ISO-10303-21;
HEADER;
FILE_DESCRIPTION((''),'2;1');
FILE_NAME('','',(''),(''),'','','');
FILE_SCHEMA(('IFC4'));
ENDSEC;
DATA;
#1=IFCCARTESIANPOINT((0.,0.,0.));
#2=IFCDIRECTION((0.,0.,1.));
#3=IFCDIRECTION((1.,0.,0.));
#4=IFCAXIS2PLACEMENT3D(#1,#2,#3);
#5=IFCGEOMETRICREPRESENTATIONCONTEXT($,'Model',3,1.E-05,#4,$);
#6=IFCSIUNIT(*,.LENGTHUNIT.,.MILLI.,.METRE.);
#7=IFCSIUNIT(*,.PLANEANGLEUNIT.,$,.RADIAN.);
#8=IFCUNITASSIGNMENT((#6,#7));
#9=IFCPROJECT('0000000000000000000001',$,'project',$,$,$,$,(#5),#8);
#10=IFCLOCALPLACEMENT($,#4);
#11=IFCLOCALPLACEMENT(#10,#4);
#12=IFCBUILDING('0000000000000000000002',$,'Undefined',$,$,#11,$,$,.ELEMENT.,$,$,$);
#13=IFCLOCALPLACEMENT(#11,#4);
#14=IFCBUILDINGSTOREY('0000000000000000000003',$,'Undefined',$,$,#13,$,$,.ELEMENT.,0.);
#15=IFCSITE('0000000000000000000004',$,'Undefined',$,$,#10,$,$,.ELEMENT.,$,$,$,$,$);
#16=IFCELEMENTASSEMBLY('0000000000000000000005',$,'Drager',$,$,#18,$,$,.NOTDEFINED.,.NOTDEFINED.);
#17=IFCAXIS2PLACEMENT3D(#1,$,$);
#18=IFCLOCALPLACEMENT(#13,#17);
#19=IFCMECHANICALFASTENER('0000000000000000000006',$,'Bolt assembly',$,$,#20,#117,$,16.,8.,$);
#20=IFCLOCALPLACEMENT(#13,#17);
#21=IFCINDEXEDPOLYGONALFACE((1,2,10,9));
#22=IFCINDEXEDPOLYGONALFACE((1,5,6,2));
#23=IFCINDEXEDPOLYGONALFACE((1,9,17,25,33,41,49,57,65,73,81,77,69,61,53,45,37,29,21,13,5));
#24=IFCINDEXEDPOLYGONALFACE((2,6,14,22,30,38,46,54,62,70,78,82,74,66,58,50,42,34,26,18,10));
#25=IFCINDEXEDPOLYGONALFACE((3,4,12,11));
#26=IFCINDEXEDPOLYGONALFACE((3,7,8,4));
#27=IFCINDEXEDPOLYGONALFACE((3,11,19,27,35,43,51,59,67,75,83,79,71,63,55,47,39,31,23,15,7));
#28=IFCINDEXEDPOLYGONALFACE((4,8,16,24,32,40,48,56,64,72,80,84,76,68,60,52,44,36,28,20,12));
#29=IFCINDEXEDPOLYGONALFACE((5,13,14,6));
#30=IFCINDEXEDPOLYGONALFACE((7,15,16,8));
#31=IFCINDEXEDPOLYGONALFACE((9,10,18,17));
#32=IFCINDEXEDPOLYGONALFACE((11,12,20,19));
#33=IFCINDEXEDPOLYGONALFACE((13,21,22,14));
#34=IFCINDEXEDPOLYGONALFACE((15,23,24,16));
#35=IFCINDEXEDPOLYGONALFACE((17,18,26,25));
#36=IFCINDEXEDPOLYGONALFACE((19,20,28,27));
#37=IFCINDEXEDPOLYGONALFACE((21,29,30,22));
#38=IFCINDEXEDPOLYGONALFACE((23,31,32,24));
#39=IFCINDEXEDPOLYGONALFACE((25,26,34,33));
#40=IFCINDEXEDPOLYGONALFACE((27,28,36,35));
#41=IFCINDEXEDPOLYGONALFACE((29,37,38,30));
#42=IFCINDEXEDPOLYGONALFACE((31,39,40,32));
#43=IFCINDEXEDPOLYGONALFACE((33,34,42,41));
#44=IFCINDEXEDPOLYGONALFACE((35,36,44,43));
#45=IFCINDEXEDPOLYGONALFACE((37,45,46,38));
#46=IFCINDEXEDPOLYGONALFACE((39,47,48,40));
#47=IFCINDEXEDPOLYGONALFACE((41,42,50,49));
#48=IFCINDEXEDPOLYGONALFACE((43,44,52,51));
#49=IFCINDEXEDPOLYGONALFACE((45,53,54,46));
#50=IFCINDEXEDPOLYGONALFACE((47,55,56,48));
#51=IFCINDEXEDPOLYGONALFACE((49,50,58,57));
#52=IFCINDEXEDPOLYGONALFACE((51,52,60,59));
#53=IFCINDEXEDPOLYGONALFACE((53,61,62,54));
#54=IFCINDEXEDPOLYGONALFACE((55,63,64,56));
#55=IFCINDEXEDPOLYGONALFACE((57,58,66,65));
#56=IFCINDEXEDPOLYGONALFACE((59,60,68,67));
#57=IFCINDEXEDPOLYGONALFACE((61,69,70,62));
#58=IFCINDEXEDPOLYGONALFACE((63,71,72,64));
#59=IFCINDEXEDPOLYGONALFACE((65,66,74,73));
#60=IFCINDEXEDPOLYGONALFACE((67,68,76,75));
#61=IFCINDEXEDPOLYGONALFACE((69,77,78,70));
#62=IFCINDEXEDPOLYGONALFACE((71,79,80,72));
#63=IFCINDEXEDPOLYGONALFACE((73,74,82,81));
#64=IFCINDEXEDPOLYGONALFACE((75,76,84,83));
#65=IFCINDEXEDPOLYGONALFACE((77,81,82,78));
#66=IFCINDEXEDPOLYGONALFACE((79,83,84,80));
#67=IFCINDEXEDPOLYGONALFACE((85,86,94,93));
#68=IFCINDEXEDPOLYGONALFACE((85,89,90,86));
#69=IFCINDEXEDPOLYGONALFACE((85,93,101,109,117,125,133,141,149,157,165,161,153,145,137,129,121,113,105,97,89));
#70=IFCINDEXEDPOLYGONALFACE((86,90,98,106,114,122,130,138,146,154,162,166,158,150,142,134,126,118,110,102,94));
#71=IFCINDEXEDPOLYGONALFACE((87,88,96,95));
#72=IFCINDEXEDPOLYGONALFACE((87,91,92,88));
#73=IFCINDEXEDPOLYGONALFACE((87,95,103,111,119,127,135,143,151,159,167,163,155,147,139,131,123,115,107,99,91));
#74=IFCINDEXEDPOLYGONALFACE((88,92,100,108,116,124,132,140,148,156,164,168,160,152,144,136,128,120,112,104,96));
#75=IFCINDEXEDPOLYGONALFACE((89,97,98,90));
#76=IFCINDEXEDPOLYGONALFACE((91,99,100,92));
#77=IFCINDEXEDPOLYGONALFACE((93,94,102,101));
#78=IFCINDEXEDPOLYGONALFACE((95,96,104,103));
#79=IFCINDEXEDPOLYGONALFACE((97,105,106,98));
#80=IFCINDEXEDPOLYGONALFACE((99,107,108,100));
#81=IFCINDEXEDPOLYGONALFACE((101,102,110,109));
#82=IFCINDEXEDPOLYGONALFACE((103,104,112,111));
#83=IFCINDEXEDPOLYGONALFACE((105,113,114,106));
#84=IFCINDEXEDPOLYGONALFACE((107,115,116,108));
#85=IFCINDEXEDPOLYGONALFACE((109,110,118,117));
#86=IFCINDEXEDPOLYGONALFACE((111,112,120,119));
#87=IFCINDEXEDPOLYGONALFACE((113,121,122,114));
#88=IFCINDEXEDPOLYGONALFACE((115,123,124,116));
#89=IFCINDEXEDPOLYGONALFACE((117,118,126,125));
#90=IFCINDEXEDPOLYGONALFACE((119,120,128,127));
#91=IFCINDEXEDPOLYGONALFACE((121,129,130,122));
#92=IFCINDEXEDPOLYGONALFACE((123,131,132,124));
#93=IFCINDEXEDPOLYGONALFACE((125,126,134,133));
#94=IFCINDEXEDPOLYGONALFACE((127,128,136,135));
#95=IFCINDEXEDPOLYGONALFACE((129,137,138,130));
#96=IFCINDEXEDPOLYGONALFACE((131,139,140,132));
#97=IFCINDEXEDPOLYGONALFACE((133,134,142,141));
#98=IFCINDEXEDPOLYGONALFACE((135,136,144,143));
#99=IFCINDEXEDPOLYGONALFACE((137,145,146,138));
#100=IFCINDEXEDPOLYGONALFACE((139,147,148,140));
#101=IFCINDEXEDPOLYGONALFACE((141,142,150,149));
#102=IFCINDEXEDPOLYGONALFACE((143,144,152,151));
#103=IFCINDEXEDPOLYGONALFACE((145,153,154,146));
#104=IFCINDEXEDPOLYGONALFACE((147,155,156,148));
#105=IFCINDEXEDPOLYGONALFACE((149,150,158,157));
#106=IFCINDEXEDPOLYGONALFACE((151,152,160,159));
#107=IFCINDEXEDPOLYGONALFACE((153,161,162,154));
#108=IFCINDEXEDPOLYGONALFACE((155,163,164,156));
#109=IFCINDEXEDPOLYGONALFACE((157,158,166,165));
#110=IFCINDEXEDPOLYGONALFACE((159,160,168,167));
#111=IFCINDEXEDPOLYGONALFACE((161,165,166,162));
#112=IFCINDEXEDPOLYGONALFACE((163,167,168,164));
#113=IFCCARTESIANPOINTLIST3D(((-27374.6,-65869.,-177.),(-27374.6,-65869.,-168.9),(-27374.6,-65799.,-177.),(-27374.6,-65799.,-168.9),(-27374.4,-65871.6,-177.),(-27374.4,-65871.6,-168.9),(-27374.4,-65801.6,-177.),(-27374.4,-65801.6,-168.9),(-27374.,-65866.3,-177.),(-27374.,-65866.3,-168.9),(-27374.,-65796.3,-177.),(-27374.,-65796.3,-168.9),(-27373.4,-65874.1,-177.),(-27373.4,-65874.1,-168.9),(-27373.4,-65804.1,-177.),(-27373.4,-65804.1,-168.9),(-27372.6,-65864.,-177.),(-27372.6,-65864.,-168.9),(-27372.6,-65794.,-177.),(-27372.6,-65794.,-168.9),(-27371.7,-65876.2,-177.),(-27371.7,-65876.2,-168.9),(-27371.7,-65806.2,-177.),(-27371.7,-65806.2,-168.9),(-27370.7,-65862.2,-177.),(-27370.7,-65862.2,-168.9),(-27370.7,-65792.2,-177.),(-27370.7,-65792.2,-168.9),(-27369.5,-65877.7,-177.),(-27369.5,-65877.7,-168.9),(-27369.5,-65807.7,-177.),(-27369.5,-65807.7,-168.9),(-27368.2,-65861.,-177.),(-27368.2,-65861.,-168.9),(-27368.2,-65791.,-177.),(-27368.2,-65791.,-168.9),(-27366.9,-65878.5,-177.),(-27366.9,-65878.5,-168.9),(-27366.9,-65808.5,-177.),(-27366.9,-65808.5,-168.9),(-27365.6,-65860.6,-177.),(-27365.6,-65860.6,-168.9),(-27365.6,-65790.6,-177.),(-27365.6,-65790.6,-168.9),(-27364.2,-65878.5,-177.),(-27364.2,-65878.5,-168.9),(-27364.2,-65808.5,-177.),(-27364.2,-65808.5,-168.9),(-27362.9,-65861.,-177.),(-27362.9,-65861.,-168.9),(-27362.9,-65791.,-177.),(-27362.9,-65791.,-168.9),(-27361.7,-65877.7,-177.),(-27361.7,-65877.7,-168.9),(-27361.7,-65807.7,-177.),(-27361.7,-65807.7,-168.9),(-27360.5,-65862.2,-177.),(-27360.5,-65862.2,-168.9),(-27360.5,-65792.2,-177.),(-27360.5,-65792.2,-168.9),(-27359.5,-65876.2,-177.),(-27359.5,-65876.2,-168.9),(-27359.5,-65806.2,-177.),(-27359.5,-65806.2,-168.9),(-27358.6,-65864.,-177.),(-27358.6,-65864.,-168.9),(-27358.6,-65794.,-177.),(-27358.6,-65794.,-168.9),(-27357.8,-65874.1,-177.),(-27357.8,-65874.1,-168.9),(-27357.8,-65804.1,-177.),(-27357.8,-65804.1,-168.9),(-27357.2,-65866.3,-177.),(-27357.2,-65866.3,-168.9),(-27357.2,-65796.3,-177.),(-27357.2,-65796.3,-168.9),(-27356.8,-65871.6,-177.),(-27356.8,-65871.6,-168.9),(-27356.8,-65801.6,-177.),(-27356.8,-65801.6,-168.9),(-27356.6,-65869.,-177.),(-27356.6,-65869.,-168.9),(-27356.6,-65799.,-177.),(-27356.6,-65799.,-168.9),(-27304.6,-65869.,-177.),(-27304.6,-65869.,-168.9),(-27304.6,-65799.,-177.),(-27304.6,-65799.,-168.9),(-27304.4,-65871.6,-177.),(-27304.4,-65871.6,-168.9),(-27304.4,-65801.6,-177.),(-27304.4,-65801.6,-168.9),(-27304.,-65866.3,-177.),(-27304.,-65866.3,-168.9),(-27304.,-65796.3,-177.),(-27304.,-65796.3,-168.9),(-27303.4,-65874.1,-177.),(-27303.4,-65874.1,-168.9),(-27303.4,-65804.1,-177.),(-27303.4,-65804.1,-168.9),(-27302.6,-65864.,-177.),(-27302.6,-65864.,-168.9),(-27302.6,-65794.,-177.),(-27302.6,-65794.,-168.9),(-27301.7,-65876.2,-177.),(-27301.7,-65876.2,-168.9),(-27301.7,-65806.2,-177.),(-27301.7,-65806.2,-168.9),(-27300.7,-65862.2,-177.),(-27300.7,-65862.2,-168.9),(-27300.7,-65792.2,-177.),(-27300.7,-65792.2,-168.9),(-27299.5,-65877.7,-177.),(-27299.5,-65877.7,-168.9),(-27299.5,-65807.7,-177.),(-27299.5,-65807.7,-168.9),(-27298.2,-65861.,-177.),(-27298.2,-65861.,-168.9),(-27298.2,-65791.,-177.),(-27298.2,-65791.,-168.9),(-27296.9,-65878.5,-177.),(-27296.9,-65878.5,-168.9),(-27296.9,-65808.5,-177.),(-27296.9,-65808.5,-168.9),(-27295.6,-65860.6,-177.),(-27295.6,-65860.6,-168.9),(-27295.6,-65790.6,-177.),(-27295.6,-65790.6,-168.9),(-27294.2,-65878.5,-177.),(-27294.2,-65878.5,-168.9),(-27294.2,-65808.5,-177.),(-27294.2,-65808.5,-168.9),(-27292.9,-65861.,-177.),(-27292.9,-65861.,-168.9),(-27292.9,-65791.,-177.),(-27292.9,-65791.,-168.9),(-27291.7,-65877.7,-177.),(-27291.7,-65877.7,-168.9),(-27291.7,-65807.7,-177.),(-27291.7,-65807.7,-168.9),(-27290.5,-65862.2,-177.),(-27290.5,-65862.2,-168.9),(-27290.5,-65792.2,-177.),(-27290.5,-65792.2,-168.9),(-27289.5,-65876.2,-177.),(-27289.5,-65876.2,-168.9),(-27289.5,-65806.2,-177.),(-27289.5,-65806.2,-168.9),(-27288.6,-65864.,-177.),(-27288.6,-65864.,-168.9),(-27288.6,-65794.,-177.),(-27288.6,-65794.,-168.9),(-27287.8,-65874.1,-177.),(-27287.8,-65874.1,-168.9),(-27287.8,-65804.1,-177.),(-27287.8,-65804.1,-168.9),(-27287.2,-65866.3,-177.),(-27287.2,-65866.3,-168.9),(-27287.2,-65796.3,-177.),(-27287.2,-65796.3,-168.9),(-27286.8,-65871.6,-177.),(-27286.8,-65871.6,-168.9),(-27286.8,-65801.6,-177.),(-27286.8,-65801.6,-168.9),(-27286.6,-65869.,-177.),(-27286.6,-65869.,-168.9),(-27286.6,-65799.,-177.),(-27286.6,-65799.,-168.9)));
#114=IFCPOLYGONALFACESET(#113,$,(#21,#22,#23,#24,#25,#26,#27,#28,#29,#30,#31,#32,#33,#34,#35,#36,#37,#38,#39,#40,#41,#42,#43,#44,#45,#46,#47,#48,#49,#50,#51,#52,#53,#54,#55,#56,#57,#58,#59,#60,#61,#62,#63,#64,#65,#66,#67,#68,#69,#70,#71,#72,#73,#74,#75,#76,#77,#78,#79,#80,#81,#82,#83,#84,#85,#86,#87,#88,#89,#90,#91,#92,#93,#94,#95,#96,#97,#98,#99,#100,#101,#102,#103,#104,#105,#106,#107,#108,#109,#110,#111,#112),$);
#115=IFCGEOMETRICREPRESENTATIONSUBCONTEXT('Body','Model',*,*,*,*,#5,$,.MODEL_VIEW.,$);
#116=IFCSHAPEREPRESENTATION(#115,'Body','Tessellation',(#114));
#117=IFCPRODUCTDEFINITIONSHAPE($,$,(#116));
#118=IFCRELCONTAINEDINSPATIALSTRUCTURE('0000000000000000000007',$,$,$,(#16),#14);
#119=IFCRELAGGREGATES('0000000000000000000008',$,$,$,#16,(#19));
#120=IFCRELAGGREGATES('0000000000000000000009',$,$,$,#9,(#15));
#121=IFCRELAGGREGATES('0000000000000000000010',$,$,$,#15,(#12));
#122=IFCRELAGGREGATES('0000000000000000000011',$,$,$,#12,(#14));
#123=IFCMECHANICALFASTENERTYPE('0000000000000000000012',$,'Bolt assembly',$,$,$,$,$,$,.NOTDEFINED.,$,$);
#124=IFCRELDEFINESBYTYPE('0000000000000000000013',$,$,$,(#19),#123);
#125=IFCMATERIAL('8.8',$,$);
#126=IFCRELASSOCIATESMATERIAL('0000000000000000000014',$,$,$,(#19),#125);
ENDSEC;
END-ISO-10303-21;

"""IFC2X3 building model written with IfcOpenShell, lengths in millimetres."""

from ifc_helpers import new_model, si_unit, frame, origin_with_axes, origin_2d_with_axis, place, context, subcontext, project, spatial, circle, extrude, source, transform, mapped, material, type_object, element, aggregate, save


model = new_model("IFC2X3")

# Units and contexts
model_context = context("Model", 3, precision=1e-05, world=origin_with_axes())
body_context = subcontext(model_context, "Body", "Model", "MODEL_VIEW")
ifc_project = project(units=[si_unit("LENGTHUNIT", "METRE", prefix="MILLI"), si_unit("PLANEANGLEUNIT", "RADIAN")], contexts=[model_context])

# Site, building, storey
site_placement = place(None, origin_with_axes())
site = spatial("IfcSite", under=ifc_project, at=site_placement, Name="Undefined", CompositionType="ELEMENT")
building_placement = place(site_placement, origin_with_axes())
building = spatial("IfcBuilding", under=site, at=building_placement, Name="Undefined", CompositionType="ELEMENT")
storey_placement = place(building_placement, origin_with_axes())
storey = spatial("IfcBuildingStorey", under=building, at=storey_placement, Name="Undefined", CompositionType="ELEMENT", Elevation=0.0)

# Element assembly
assembly_1_placement = place(storey_placement, origin_with_axes())
assembly_1 = element("IfcElementAssembly", 1, at=assembly_1_placement, inside=storey, Name="Drager", AssemblyPlace="NOTDEFINED", PredefinedType="NOTDEFINED")

# Mechanical fastener
ifc_material_1 = material(Name="8.8")
mechanical_fastener_type = type_object("IfcMechanicalFastenerType", Name="Bolt assembly")
shared_shape_1 = source(origin_with_axes(), body_context, "Body", "SweptSolid", [
    extrude(circle(Radius=9.0, at=origin_2d_with_axis()), frame((0.0, 0.0, 0.0), z_axis=(0.0, 1.0, 0.0), x_axis=(1.0, 0.0, 0.0)), (0.0, 0.0, 1.0), 8.1),
])
mechanical_fastener_1_placement = place(assembly_1_placement, frame((-27330.6, -65869.6, -177.0), z_axis=(1.0, 0.0, 0.0), x_axis=(0.0, 1.0, 0.0)))
mechanical_fastener_1 = element("IfcMechanicalFastener", 2, at=mechanical_fastener_1_placement, type_object=mechanical_fastener_type, material=ifc_material_1, Name="Bolt assembly", NominalDiameter=16.0, NominalLength=8.0, context=body_context, shape_type="MappedRepresentation", body=[
    mapped(shared_shape_1, transform((0.0, 0.0, -35.0))),
    mapped(shared_shape_1, transform((70.0, 0.0, -35.0))),
    mapped(shared_shape_1, transform((0.0, 0.0, 35.0))),
    mapped(shared_shape_1, transform((70.0, 0.0, 35.0))),
])
aggregate(assembly_1, [mechanical_fastener_1])

save(model, "model.ifc")
